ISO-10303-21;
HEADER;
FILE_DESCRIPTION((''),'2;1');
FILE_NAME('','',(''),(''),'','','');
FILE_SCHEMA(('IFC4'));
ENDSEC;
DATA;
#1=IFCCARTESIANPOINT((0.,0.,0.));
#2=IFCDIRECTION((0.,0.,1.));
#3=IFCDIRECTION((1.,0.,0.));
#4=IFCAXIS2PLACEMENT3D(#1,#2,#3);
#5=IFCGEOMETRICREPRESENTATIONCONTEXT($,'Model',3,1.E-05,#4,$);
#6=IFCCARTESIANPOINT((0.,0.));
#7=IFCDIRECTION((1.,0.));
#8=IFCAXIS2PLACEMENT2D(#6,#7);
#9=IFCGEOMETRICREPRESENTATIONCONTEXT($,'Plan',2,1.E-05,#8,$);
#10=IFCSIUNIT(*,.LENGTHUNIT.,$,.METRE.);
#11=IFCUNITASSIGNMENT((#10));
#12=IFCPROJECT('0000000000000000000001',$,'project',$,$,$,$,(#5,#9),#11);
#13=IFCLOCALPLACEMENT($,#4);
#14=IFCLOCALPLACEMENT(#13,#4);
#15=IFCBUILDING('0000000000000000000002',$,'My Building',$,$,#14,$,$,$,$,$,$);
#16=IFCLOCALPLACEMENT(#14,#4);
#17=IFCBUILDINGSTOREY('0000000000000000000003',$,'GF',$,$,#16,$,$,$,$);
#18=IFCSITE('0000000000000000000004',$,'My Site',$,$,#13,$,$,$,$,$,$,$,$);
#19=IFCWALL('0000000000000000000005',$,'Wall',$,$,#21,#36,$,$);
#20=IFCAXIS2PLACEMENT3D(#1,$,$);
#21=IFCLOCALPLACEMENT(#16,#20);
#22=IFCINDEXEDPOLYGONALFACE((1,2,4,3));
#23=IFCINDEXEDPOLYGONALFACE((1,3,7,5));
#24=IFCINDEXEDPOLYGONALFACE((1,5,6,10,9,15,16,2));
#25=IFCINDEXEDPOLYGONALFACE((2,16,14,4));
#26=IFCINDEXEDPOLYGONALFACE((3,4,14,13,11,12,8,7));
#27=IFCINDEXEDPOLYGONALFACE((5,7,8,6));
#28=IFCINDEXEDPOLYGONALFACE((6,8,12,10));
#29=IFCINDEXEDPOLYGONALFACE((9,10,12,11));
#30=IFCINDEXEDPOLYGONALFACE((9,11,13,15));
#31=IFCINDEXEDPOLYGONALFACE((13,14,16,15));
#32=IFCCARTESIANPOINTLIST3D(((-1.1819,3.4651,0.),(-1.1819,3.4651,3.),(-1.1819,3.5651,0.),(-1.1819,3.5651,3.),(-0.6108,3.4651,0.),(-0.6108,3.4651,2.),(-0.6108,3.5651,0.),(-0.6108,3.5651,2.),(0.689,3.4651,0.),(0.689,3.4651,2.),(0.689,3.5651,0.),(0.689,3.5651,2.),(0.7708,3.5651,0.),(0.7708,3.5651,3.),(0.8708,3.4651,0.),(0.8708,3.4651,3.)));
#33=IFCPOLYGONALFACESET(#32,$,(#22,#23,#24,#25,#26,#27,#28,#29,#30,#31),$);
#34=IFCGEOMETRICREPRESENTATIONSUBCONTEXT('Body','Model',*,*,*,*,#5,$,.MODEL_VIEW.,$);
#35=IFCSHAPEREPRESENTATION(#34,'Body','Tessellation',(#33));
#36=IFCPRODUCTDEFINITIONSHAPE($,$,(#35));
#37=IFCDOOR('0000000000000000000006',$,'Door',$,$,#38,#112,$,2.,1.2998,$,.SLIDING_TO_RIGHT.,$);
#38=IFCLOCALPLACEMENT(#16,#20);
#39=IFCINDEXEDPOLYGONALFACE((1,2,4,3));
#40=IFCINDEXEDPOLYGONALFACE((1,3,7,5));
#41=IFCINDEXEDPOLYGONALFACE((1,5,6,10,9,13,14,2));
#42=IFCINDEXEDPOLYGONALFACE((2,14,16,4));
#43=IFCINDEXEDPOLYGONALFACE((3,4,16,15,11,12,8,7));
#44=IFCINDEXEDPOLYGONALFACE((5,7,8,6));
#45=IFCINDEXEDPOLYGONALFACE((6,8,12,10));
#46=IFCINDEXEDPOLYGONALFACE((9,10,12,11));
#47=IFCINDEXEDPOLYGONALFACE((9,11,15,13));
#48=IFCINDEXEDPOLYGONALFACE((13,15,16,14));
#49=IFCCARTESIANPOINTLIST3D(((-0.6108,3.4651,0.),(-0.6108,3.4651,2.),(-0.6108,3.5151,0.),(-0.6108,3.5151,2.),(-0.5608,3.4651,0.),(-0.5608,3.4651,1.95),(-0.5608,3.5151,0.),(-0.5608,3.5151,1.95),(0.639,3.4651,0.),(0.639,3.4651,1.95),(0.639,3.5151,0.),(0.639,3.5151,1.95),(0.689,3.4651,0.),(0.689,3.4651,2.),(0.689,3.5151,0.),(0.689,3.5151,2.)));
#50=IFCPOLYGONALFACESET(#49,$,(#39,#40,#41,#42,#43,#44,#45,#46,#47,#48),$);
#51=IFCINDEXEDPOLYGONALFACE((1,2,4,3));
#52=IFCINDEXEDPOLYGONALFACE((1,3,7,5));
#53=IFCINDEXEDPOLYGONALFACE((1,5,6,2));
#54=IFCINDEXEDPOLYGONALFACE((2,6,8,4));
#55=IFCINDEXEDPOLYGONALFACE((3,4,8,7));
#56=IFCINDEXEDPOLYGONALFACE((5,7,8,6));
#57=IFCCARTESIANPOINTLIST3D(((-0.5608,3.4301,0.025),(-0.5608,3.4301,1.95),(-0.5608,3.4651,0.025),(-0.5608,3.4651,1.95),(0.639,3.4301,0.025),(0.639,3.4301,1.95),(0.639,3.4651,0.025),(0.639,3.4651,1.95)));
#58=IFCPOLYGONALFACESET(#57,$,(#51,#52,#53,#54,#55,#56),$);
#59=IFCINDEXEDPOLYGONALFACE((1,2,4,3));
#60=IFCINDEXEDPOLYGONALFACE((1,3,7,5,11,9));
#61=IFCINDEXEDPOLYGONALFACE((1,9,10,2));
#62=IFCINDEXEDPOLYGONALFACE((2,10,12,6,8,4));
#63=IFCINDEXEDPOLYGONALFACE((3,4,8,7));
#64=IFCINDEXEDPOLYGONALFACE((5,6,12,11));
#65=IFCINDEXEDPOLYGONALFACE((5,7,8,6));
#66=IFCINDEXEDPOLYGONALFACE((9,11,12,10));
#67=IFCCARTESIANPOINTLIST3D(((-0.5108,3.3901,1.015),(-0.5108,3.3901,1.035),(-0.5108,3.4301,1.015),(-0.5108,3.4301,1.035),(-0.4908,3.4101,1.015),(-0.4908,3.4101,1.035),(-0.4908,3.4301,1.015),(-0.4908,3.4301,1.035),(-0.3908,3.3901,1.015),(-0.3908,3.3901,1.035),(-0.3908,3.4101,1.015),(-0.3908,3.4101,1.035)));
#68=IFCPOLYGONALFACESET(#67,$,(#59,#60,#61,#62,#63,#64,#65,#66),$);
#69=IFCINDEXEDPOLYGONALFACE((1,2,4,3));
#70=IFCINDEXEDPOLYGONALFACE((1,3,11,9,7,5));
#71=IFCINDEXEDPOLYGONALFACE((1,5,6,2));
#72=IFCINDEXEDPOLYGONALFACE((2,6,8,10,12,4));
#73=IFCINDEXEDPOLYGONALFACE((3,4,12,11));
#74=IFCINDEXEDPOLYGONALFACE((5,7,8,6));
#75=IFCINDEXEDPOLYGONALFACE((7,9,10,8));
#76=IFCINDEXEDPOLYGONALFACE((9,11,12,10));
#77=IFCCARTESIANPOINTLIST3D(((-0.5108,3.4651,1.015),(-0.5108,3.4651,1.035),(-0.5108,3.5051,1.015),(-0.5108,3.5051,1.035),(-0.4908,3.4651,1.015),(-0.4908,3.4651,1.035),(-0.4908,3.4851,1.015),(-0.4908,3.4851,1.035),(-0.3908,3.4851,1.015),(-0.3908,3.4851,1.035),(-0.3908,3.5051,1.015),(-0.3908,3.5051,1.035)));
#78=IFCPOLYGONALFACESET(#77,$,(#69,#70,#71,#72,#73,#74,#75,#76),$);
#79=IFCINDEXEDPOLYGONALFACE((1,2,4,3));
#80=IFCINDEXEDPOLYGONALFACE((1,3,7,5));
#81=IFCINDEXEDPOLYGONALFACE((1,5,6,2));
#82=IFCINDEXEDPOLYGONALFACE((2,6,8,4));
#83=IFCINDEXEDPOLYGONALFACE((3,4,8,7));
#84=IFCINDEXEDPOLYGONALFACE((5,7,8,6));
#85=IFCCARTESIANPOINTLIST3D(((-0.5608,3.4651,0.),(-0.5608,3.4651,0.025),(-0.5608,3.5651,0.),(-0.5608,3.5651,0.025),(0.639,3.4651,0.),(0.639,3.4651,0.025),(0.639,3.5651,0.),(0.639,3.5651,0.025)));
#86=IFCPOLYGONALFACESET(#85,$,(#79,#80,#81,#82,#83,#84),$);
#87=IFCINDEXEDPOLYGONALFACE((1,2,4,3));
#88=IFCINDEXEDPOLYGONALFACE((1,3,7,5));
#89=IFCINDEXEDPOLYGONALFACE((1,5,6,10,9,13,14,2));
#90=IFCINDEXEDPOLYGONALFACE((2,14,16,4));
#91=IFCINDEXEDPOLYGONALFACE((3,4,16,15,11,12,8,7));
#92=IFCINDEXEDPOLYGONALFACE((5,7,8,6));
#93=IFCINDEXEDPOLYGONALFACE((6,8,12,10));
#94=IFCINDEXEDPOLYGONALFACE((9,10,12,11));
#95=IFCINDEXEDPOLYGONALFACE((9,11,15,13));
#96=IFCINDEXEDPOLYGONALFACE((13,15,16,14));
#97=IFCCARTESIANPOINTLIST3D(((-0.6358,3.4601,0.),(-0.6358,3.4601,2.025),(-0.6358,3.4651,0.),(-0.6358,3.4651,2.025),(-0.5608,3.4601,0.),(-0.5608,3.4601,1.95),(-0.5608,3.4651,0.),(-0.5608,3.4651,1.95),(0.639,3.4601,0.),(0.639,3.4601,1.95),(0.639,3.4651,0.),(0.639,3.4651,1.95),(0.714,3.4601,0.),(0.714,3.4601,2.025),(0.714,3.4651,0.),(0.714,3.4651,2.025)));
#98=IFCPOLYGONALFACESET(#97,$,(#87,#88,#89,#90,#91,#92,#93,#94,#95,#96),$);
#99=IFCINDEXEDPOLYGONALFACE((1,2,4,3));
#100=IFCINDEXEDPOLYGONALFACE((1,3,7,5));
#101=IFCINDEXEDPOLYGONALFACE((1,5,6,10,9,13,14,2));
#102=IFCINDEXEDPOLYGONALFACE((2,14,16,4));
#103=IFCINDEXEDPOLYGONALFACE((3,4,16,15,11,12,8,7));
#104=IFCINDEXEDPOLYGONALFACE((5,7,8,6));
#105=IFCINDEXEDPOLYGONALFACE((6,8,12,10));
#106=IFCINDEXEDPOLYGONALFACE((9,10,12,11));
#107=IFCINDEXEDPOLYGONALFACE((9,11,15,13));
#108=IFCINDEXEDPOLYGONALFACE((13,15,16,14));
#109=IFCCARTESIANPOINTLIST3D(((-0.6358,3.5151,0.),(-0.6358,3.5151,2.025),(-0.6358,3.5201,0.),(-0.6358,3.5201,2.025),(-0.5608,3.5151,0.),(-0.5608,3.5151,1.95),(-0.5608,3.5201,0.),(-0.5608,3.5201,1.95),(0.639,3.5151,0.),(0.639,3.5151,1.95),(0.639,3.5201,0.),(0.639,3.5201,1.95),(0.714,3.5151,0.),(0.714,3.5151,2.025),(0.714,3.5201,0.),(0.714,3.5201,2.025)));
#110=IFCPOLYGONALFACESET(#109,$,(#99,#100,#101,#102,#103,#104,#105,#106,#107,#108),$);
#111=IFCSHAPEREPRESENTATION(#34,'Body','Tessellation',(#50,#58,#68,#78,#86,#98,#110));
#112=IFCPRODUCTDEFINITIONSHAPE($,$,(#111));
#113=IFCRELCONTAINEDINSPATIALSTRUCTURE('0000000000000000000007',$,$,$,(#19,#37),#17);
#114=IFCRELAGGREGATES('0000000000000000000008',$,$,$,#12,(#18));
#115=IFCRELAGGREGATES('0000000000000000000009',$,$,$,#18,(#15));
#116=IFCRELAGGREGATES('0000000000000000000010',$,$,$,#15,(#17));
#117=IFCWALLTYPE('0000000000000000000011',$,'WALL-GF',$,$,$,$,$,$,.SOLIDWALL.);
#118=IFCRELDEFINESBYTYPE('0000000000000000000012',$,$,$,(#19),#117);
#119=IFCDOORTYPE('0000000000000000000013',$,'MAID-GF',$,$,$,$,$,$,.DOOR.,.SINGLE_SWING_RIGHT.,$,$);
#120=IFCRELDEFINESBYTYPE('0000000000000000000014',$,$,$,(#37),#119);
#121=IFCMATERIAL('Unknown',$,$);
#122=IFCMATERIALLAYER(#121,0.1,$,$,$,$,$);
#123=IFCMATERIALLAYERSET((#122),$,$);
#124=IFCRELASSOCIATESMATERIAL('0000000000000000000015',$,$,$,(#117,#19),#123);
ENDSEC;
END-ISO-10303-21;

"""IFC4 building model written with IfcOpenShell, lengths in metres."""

from ifc_helpers import new_model, entity, si_unit, frame, origin_with_axes, origin_2d_with_axis, place, context, subcontext, project, spatial, line, indexed_curve, outline, extrude, shape, source, transform, mapped, material, layer, layer_set, layer_usage, type_object, type_shapes, element, fill, save


model = new_model("IFC4")

# Units and contexts
model_context = context("Model", 3, precision=1e-05, world=origin_with_axes())
plan_context = context("Plan", 2, precision=1e-05, world=origin_2d_with_axis())
body_context_1 = subcontext(model_context, "Body", "Model", "MODEL_VIEW")
body_context_2 = subcontext(plan_context, "Body", "Plan", "PLAN_VIEW")
ifc_project = project(units=[si_unit("LENGTHUNIT", "METRE")], contexts=[model_context, plan_context])

# Site, building, storey
site_placement = place(None, origin_with_axes())
site = spatial("IfcSite", under=ifc_project, at=site_placement, Name="My Site")
building_placement = place(site_placement, origin_with_axes())
building = spatial("IfcBuilding", under=site, at=building_placement, Name="My Building")
storey_placement = place(building_placement, origin_with_axes())
storey = spatial("IfcBuildingStorey", under=building, at=storey_placement, Name="GF")

# Shared definitions
ifc_material_1 = material(Name="Unknown")

# Shared definitions
ifc_layer_1 = layer(ifc_material_1, 0.1)
ifc_layer_set_1 = layer_set([ifc_layer_1])
wall_type = type_object("IfcWallType", Name="WALL-GF", PredefinedType="SOLIDWALL", material=ifc_layer_set_1)

# Wall, opening, door
ifc_layer_usage_1 = layer_usage(ifc_layer_set_1, "AXIS2", "POSITIVE", 0.0)
wall_1_placement = place(storey_placement, frame((0.7708, 3.5651, 0.0), z_axis=(0.0, 0.0, 1.0), x_axis=(-1.0, 0.0, 0.0)))
wall_1 = element("IfcWall", 1, at=wall_1_placement, inside=storey, type_object=wall_type, material=ifc_layer_usage_1, Name="Wall", context=body_context_1, shape_type="SweptSolid", body=[
    extrude(outline(indexed_curve([(0.0, 0.0), (-0.1, 0.1), (1.9528, 0.1), (1.9528, 0.0)], segments=[line(1, 2, 3, 4, 1)])), origin_with_axes(), (0.0, 0.0, 1.0), 3.0),
])
shared_shape_1 = source(origin_with_axes(), body_context_1, "Body", "SweptSolid", [
    extrude(outline(indexed_curve([(0.0, 0.0), (1.2998, 0.0), (1.2998, 2.0), (0.0, 2.0)], segments=[line(1, 2, 3, 4, 1)])), frame((0.0, -0.6, 0.0), z_axis=(0.0, -1.0, 0.0), x_axis=(1.0, 0.0, 0.0)), (0.0, 0.0, -1.0), 1.2),
])
opening_1_placement = place(wall_1_placement, frame((1.3816, 0.1, 0.0), z_axis=(0.0, 0.0, 1.0), x_axis=(-1.0, 0.0, 0.0)))
opening_1 = element("IfcOpeningElement", 2, at=opening_1_placement, cuts=wall_1, PredefinedType="OPENING", context=body_context_1, shape_type="MappedRepresentation", body=[
    mapped(shared_shape_1, transform((0.0, 0.0, 0.0), x_axis=(1.0, 0.0, 0.0), y_axis=(0.0, 1.0, 0.0), z_axis=(0.0, 0.0, 1.0), scale=1.0)),
])
door_type_1 = type_object("IfcDoorType", Name="MAID-GF", OperationType="SINGLE_SWING_RIGHT", PredefinedType="DOOR")
shared_shape_2 = source(origin_with_axes(), body_context_1, "Body", "SweptSolid", [
    extrude(outline(indexed_curve([(0.0, 0.0), (0.0, 2.0), (1.2998, 2.0), (1.2998, 0.0), (1.2498, 0.0), (1.2498, 1.95), (0.05, 1.95), (0.05, 0.0)], segments=[line(1, 2, 3, 4, 5, 6, 7, 8, 1)])), frame((0.0, 0.0, 0.0), z_axis=(0.0, -1.0, 0.0), x_axis=(1.0, 0.0, 0.0)), (0.0, 0.0, -1.0), 0.05),
    extrude(outline(indexed_curve([(0.0, 0.0), (1.1998, 0.0), (1.1998, 0.035), (0.0, 0.035)], segments=[line(1, 2, 3, 4, 1)])), frame((0.05, -0.035, 0.025), z_axis=(0.0, 0.0, 1.0), x_axis=(1.0, 0.0, 0.0)), (0.0, 0.0, 1.0), 1.925),
    extrude(outline(indexed_curve([(0.0, 0.0), (0.0, -0.04), (0.12, -0.04), (0.12, -0.02), (0.02, -0.02), (0.02, 0.0)], segments=[line(1, 2, 3, 4, 5, 6, 1)])), frame((0.1, -0.035, 1.015), z_axis=(0.0, 0.0, 1.0), x_axis=(1.0, 0.0, 0.0)), (0.0, 0.0, 1.0), 0.02),
    extrude(outline(indexed_curve([(0.0, 0.0), (0.0, 0.04), (0.12, 0.04), (0.12, 0.02), (0.02, 0.02), (0.02, 0.0)], segments=[line(1, 2, 3, 4, 5, 6, 1)])), frame((0.1, 0.0, 1.015), z_axis=(0.0, 0.0, 1.0), x_axis=(1.0, 0.0, 0.0)), (0.0, 0.0, 1.0), 0.02),
    extrude(outline(indexed_curve([(0.0, 0.0), (1.1998, 0.0), (1.1998, 0.1), (0.0, 0.1)], segments=[line(1, 2, 3, 4, 1)])), frame((0.05, 0.0, 0.0), z_axis=(0.0, 0.0, 1.0), x_axis=(1.0, 0.0, 0.0)), (0.0, 0.0, 1.0), 0.025),
    extrude(outline(indexed_curve([(0.0, 0.0), (0.0, 2.025), (1.3498, 2.025), (1.3498, 0.0), (1.2748, 0.0), (1.2748, 1.95), (0.075, 1.95), (0.075, 0.0)], segments=[line(1, 2, 3, 4, 5, 6, 7, 8, 1)])), frame((-0.025, -0.005, 0.0), z_axis=(0.0, -1.0, 0.0), x_axis=(1.0, 0.0, 0.0)), (0.0, 0.0, -1.0), 0.005),
    extrude(outline(indexed_curve([(0.0, 0.0), (0.0, 2.025), (1.3498, 2.025), (1.3498, 0.0), (1.2748, 0.0), (1.2748, 1.95), (0.075, 1.95), (0.075, 0.0)], segments=[line(1, 2, 3, 4, 5, 6, 7, 8, 1)])), frame((-0.025, 0.05, 0.0), z_axis=(0.0, -1.0, 0.0), x_axis=(1.0, 0.0, 0.0)), (0.0, 0.0, -1.0), 0.005),
])
shared_shape_3 = source(origin_with_axes(), body_context_2, "Body", "Curve2D", [
    entity("IfcIndexedPolyCurve", entity("IfcCartesianPointList2D", [[0.0, 0.0], [0.05, 0.0], [0.05, 0.05], [0.0, 0.05]]), [entity("IfcLineIndex", [1, 2, 3, 4, 1])]),
    entity("IfcIndexedPolyCurve", entity("IfcCartesianPointList2D", [[1.2998, 0.0], [1.2498, 0.0], [1.2498, 0.05], [1.2998, 0.05]]), [entity("IfcLineIndex", [1, 2, 3, 4, 1])]),
    entity("IfcIndexedPolyCurve", entity("IfcCartesianPointList2D", [[1.8497, -0.035], [0.6499, -0.035], [0.6499, 0.0], [1.8497, 0.0]]), [entity("IfcLineIndex", [1, 2, 3, 4, 1])]),
])
type_shapes(door_type_1, [shared_shape_2, shared_shape_3])
door_1_placement = place(opening_1_placement, frame((0.0, 0.0, 0.0), z_axis=(0.0, 0.0, 1.0), x_axis=(1.0, 0.0, 0.0)))
door_1 = element("IfcDoor", 3, at=door_1_placement, inside=storey, type_object=door_type_1, Name="Door", OperationType="SLIDING_TO_RIGHT", OverallHeight=2.0, OverallWidth=1.2998, shapes=[
    shape(body_context_1, "Body", "MappedRepresentation", [mapped(shared_shape_2, transform((0.0, 0.0, 0.0), x_axis=(1.0, 0.0, 0.0), y_axis=(0.0, 1.0, 0.0), z_axis=(0.0, 0.0, 1.0), scale=1.0))]),
    shape(body_context_2, "Body", "MappedRepresentation", [mapped(shared_shape_3, transform((0.0, 0.0, 0.0), x_axis=(1.0, 0.0, 0.0), y_axis=(0.0, 1.0, 0.0), z_axis=(0.0, 0.0, 1.0), scale=1.0))]),
])
fill(opening_1, door_1)

save(model, "model.ifc")
